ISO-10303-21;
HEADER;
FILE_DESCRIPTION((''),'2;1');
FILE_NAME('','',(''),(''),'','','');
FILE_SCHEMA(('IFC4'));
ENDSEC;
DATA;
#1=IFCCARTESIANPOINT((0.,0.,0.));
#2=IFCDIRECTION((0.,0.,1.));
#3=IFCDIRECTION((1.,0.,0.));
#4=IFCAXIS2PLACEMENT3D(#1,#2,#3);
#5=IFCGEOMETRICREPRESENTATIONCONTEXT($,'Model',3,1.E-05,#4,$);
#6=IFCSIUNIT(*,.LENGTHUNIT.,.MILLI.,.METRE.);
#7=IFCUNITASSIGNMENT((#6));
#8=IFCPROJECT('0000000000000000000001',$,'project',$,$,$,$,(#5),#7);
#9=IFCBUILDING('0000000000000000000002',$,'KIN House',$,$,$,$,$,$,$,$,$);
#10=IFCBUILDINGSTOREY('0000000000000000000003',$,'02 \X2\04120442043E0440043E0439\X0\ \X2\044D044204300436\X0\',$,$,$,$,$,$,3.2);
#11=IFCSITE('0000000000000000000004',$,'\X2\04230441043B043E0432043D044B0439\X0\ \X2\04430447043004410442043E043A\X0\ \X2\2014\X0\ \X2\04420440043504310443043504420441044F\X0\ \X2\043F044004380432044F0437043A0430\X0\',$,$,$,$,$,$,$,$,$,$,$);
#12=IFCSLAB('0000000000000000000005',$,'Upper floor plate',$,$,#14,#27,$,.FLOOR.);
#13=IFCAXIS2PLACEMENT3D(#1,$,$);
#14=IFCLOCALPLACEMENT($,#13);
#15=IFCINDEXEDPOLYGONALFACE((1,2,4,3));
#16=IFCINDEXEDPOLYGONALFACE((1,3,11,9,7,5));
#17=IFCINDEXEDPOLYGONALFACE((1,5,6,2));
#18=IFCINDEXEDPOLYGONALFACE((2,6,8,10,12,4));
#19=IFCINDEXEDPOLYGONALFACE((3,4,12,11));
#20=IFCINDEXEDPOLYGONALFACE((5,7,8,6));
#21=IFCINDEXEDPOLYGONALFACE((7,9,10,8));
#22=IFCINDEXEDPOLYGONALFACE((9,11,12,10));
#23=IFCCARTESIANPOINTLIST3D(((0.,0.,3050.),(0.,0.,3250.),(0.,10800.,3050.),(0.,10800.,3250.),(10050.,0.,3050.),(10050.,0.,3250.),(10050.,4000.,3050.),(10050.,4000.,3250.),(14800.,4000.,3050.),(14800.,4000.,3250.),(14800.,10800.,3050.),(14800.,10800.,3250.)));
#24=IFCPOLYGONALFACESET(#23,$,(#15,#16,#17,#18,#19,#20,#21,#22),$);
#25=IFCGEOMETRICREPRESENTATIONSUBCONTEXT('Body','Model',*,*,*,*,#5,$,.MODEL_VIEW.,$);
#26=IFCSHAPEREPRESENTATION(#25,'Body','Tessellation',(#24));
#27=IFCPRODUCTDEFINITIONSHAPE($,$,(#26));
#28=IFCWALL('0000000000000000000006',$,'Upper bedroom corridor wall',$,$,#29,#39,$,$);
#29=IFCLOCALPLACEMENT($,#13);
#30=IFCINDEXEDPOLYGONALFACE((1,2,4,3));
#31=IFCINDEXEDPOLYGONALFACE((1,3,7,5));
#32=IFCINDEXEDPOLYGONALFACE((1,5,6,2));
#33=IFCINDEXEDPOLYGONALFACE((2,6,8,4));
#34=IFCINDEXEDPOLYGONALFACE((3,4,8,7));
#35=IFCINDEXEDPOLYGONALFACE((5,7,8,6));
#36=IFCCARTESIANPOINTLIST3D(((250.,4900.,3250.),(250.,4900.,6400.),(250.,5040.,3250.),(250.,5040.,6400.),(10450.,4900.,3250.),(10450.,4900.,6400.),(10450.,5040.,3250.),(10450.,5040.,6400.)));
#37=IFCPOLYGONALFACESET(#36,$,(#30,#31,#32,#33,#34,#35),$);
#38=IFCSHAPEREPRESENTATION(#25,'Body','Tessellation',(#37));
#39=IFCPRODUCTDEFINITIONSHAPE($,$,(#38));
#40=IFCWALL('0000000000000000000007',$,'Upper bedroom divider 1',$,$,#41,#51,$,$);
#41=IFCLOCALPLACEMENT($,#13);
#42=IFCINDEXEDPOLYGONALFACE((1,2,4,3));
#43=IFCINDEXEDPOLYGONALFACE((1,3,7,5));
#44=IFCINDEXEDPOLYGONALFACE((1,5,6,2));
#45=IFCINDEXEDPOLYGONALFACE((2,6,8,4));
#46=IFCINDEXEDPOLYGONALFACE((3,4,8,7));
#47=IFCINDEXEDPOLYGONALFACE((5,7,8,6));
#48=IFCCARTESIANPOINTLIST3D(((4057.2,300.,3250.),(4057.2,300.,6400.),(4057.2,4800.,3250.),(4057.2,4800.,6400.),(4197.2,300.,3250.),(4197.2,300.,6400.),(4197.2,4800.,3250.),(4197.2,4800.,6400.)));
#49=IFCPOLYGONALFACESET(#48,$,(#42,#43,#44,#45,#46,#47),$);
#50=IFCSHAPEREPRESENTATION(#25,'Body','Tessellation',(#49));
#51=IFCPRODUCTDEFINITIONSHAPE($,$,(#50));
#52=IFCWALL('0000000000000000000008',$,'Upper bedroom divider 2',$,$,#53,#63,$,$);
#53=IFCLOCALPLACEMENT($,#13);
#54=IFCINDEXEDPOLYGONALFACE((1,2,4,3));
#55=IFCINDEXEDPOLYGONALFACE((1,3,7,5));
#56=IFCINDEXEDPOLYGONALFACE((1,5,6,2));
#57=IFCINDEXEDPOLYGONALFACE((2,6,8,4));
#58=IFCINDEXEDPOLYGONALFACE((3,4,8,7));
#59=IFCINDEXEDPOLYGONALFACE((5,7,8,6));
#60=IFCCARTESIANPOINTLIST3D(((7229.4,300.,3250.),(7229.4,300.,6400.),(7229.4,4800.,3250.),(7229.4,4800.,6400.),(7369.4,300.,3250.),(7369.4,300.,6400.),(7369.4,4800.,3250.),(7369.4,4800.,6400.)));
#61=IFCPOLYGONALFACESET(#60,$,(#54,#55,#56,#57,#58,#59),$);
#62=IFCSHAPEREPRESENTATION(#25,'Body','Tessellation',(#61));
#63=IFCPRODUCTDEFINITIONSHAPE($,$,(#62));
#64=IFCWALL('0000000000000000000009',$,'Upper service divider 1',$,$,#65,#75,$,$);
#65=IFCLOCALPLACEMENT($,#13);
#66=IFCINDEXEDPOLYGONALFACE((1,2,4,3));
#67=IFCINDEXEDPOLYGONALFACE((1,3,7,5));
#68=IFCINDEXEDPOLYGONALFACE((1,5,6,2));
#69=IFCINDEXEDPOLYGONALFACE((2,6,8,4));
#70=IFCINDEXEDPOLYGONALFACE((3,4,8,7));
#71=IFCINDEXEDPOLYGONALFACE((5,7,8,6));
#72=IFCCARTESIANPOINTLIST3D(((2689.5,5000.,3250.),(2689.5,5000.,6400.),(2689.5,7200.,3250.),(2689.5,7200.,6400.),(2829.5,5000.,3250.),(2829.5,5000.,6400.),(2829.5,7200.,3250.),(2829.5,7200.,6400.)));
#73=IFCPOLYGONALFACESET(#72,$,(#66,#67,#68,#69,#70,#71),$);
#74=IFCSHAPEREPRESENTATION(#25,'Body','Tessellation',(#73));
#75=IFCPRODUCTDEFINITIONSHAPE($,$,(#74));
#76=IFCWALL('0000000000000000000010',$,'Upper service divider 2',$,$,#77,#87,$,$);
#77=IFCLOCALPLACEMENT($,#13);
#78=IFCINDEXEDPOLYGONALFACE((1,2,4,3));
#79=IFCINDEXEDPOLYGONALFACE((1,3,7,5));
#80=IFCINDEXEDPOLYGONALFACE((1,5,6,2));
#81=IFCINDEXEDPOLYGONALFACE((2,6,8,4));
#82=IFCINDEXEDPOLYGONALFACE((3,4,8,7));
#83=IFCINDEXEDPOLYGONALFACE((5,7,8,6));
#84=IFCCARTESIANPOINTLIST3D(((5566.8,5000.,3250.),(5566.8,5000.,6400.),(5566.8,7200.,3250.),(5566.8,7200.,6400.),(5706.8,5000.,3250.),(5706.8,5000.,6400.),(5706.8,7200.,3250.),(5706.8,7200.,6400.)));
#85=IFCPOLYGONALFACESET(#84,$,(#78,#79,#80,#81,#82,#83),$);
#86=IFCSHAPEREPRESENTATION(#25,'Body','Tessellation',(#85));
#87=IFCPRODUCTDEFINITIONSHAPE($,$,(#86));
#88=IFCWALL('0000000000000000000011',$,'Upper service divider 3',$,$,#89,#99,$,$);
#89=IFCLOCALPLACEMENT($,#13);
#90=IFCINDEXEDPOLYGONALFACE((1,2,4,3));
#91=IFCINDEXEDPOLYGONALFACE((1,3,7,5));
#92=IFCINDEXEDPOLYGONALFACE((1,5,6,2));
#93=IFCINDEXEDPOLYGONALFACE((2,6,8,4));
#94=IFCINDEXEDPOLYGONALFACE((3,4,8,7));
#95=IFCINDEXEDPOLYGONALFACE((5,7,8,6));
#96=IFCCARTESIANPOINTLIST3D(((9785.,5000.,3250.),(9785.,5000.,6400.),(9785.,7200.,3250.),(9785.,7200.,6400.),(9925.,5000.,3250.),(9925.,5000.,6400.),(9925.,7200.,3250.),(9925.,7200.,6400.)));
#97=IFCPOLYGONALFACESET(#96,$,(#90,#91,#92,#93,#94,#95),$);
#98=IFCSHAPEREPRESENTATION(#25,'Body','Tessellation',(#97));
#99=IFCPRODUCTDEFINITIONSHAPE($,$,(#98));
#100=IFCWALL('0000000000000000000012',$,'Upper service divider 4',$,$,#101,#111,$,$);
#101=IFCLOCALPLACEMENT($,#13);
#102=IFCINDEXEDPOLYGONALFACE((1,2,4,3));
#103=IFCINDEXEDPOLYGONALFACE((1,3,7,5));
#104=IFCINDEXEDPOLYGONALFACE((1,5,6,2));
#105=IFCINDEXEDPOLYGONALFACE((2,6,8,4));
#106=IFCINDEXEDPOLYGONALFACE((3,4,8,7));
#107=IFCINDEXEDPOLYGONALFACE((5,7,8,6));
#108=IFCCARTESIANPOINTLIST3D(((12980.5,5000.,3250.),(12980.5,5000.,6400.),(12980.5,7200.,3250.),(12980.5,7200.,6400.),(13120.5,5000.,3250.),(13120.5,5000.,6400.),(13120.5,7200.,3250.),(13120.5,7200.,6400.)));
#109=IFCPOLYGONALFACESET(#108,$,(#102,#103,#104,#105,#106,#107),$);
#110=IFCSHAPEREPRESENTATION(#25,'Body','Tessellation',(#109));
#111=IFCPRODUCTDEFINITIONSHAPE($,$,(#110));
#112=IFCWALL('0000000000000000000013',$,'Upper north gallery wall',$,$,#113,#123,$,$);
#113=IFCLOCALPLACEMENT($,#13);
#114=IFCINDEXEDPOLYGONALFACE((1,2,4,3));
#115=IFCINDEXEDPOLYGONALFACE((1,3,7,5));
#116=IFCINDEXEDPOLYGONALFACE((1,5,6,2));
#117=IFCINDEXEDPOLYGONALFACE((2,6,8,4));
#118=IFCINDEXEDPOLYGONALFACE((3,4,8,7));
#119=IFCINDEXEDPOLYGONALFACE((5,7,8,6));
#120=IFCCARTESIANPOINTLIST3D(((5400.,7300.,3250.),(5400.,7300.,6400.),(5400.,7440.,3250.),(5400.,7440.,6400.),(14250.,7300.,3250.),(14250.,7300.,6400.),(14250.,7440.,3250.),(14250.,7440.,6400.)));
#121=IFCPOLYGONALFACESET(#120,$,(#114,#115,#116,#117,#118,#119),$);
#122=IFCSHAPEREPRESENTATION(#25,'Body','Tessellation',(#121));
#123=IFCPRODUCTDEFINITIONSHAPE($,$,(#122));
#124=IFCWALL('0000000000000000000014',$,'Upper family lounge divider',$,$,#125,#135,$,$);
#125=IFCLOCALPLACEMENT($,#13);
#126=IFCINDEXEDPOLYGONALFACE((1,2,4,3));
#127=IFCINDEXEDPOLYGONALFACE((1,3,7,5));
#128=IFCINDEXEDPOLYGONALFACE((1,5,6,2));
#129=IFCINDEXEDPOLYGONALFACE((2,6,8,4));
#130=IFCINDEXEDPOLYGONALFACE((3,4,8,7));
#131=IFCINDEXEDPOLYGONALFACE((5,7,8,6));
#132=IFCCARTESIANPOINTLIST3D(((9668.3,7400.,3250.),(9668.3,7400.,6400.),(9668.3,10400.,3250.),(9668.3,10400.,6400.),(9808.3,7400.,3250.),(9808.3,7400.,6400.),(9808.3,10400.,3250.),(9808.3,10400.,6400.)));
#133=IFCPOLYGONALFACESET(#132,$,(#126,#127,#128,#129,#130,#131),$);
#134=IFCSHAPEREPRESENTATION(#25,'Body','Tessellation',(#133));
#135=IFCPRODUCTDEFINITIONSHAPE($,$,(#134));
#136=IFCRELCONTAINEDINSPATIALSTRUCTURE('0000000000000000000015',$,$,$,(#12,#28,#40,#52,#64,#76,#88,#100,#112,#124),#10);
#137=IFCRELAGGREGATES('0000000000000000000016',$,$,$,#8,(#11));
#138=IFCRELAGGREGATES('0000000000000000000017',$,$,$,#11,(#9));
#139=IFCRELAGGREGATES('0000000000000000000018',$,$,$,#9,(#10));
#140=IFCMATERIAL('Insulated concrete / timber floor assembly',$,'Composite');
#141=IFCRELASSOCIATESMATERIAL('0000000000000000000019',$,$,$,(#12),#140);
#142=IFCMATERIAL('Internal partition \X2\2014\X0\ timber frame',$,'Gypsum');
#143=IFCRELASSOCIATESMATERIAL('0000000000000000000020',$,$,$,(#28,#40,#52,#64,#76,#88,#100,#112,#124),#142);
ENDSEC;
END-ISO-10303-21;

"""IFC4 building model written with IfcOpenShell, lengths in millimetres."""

from ifc_helpers import new_model, si_unit, frame, origin_with_axes, place, context, subcontext, project, spatial, indexed_curve, outline, extrude, material, element, save


model = new_model("IFC4")

# Units and contexts
model_context = context("Model", 3, precision=1e-05, world=origin_with_axes())
body_context = subcontext(model_context, "Body", "Model", "MODEL_VIEW")
ifc_project = project(units=[si_unit("LENGTHUNIT", "METRE", prefix="MILLI")], contexts=[model_context])

# Site, building, storey
site = spatial("IfcSite", under=ifc_project, Name="Условный участок — требуется привязка")
building = spatial("IfcBuilding", under=site, Name="KIN House")
storey = spatial("IfcBuildingStorey", under=building, Name="02 Второй этаж", Elevation=3.2)

# Slab
ifc_material_1 = material(Name="Insulated concrete / timber floor assembly", Category="Composite")
slab_placement = place(None, frame((0.0, 0.0, 3050.0), z_axis=(0.0, 0.0, 1.0), x_axis=(1.0, 0.0, 0.0)))
element("IfcSlab", 1, at=slab_placement, inside=storey, material=ifc_material_1, Name="Upper floor plate", PredefinedType="FLOOR", context=body_context, shape_type="SweptSolid", body=[
    extrude(outline(indexed_curve([(0.0, 0.0), (10050.0, 0.0), (10050.0, 4000.0), (14800.0, 4000.0), (14800.0, 10800.0), (0.0, 10800.0)])), None, (0.0, 0.0, 1.0), 200.0),
])

# Walls
ifc_material_2 = material(Name="Internal partition — timber frame", Category="Gypsum")
wall_1_placement = place(None, frame((250.0, 4900.0, 3250.0), z_axis=(0.0, 0.0, 1.0), x_axis=(1.0, 0.0, 0.0)))
element("IfcWall", 2, at=wall_1_placement, inside=storey, material=ifc_material_2, Name="Upper bedroom corridor wall", context=body_context, shape_type="SweptSolid", body=[
    extrude(outline(indexed_curve([(0.0, 0.0), (0.0, 140.0), (10200.0, 140.0), (10200.0, 0.0), (0.0, 0.0)], self_intersect=False)), origin_with_axes(), (0.0, 0.0, 1.0), 3150.0),
])
for number, where, z_axis, x_axis, name in (
    (3, (4197.2, 300.0, 3250.0), (0.0, 0.0, 1.0), (0.0, 1.0, 0.0), "Upper bedroom divider 1"),
    (4, (7369.4, 300.0, 3250.0), (0.0, 0.0, 1.0), (0.0, 1.0, 0.0), "Upper bedroom divider 2"),
):
    element("IfcWall", number, at=place(None, frame(where, z_axis=z_axis, x_axis=x_axis)), inside=storey, material=ifc_material_2, Name=name, context=body_context, shape_type="SweptSolid", body=[
        extrude(outline(indexed_curve([(0.0, 0.0), (0.0, 140.0), (4500.0, 140.0), (4500.0, 0.0), (0.0, 0.0)], self_intersect=False)), origin_with_axes(), (0.0, 0.0, 1.0), 3150.0),
    ])
for number, where, z_axis, x_axis, name in (
    (5, (2829.5, 5000.0, 3250.0), (0.0, 0.0, 1.0), (0.0, 1.0, 0.0), "Upper service divider 1"),
    (6, (5706.8, 5000.0, 3250.0), (0.0, 0.0, 1.0), (0.0, 1.0, 0.0), "Upper service divider 2"),
    (7, (9925.0, 5000.0, 3250.0), (0.0, 0.0, 1.0), (0.0, 1.0, 0.0), "Upper service divider 3"),
    (8, (13120.5, 5000.0, 3250.0), (0.0, 0.0, 1.0), (0.0, 1.0, 0.0), "Upper service divider 4"),
):
    element("IfcWall", number, at=place(None, frame(where, z_axis=z_axis, x_axis=x_axis)), inside=storey, material=ifc_material_2, Name=name, context=body_context, shape_type="SweptSolid", body=[
        extrude(outline(indexed_curve([(0.0, 0.0), (0.0, 140.0), (2200.0, 140.0), (2200.0, 0.0), (0.0, 0.0)], self_intersect=False)), origin_with_axes(), (0.0, 0.0, 1.0), 3150.0),
    ])
wall_2_placement = place(None, frame((5400.0, 7300.0, 3250.0), z_axis=(0.0, 0.0, 1.0), x_axis=(1.0, 0.0, 0.0)))
element("IfcWall", 9, at=wall_2_placement, inside=storey, material=ifc_material_2, Name="Upper north gallery wall", context=body_context, shape_type="SweptSolid", body=[
    extrude(outline(indexed_curve([(0.0, 0.0), (0.0, 140.0), (8850.0, 140.0), (8850.0, 0.0), (0.0, 0.0)], self_intersect=False)), origin_with_axes(), (0.0, 0.0, 1.0), 3150.0),
])
wall_3_placement = place(None, frame((9808.3, 7400.0, 3250.0), z_axis=(0.0, 0.0, 1.0), x_axis=(0.0, 1.0, 0.0)))
element("IfcWall", 10, at=wall_3_placement, inside=storey, material=ifc_material_2, Name="Upper family lounge divider", context=body_context, shape_type="SweptSolid", body=[
    extrude(outline(indexed_curve([(0.0, 0.0), (0.0, 140.0), (3000.0, 140.0), (3000.0, 0.0), (0.0, 0.0)], self_intersect=False)), origin_with_axes(), (0.0, 0.0, 1.0), 3150.0),
])

save(model, "model.ifc")
